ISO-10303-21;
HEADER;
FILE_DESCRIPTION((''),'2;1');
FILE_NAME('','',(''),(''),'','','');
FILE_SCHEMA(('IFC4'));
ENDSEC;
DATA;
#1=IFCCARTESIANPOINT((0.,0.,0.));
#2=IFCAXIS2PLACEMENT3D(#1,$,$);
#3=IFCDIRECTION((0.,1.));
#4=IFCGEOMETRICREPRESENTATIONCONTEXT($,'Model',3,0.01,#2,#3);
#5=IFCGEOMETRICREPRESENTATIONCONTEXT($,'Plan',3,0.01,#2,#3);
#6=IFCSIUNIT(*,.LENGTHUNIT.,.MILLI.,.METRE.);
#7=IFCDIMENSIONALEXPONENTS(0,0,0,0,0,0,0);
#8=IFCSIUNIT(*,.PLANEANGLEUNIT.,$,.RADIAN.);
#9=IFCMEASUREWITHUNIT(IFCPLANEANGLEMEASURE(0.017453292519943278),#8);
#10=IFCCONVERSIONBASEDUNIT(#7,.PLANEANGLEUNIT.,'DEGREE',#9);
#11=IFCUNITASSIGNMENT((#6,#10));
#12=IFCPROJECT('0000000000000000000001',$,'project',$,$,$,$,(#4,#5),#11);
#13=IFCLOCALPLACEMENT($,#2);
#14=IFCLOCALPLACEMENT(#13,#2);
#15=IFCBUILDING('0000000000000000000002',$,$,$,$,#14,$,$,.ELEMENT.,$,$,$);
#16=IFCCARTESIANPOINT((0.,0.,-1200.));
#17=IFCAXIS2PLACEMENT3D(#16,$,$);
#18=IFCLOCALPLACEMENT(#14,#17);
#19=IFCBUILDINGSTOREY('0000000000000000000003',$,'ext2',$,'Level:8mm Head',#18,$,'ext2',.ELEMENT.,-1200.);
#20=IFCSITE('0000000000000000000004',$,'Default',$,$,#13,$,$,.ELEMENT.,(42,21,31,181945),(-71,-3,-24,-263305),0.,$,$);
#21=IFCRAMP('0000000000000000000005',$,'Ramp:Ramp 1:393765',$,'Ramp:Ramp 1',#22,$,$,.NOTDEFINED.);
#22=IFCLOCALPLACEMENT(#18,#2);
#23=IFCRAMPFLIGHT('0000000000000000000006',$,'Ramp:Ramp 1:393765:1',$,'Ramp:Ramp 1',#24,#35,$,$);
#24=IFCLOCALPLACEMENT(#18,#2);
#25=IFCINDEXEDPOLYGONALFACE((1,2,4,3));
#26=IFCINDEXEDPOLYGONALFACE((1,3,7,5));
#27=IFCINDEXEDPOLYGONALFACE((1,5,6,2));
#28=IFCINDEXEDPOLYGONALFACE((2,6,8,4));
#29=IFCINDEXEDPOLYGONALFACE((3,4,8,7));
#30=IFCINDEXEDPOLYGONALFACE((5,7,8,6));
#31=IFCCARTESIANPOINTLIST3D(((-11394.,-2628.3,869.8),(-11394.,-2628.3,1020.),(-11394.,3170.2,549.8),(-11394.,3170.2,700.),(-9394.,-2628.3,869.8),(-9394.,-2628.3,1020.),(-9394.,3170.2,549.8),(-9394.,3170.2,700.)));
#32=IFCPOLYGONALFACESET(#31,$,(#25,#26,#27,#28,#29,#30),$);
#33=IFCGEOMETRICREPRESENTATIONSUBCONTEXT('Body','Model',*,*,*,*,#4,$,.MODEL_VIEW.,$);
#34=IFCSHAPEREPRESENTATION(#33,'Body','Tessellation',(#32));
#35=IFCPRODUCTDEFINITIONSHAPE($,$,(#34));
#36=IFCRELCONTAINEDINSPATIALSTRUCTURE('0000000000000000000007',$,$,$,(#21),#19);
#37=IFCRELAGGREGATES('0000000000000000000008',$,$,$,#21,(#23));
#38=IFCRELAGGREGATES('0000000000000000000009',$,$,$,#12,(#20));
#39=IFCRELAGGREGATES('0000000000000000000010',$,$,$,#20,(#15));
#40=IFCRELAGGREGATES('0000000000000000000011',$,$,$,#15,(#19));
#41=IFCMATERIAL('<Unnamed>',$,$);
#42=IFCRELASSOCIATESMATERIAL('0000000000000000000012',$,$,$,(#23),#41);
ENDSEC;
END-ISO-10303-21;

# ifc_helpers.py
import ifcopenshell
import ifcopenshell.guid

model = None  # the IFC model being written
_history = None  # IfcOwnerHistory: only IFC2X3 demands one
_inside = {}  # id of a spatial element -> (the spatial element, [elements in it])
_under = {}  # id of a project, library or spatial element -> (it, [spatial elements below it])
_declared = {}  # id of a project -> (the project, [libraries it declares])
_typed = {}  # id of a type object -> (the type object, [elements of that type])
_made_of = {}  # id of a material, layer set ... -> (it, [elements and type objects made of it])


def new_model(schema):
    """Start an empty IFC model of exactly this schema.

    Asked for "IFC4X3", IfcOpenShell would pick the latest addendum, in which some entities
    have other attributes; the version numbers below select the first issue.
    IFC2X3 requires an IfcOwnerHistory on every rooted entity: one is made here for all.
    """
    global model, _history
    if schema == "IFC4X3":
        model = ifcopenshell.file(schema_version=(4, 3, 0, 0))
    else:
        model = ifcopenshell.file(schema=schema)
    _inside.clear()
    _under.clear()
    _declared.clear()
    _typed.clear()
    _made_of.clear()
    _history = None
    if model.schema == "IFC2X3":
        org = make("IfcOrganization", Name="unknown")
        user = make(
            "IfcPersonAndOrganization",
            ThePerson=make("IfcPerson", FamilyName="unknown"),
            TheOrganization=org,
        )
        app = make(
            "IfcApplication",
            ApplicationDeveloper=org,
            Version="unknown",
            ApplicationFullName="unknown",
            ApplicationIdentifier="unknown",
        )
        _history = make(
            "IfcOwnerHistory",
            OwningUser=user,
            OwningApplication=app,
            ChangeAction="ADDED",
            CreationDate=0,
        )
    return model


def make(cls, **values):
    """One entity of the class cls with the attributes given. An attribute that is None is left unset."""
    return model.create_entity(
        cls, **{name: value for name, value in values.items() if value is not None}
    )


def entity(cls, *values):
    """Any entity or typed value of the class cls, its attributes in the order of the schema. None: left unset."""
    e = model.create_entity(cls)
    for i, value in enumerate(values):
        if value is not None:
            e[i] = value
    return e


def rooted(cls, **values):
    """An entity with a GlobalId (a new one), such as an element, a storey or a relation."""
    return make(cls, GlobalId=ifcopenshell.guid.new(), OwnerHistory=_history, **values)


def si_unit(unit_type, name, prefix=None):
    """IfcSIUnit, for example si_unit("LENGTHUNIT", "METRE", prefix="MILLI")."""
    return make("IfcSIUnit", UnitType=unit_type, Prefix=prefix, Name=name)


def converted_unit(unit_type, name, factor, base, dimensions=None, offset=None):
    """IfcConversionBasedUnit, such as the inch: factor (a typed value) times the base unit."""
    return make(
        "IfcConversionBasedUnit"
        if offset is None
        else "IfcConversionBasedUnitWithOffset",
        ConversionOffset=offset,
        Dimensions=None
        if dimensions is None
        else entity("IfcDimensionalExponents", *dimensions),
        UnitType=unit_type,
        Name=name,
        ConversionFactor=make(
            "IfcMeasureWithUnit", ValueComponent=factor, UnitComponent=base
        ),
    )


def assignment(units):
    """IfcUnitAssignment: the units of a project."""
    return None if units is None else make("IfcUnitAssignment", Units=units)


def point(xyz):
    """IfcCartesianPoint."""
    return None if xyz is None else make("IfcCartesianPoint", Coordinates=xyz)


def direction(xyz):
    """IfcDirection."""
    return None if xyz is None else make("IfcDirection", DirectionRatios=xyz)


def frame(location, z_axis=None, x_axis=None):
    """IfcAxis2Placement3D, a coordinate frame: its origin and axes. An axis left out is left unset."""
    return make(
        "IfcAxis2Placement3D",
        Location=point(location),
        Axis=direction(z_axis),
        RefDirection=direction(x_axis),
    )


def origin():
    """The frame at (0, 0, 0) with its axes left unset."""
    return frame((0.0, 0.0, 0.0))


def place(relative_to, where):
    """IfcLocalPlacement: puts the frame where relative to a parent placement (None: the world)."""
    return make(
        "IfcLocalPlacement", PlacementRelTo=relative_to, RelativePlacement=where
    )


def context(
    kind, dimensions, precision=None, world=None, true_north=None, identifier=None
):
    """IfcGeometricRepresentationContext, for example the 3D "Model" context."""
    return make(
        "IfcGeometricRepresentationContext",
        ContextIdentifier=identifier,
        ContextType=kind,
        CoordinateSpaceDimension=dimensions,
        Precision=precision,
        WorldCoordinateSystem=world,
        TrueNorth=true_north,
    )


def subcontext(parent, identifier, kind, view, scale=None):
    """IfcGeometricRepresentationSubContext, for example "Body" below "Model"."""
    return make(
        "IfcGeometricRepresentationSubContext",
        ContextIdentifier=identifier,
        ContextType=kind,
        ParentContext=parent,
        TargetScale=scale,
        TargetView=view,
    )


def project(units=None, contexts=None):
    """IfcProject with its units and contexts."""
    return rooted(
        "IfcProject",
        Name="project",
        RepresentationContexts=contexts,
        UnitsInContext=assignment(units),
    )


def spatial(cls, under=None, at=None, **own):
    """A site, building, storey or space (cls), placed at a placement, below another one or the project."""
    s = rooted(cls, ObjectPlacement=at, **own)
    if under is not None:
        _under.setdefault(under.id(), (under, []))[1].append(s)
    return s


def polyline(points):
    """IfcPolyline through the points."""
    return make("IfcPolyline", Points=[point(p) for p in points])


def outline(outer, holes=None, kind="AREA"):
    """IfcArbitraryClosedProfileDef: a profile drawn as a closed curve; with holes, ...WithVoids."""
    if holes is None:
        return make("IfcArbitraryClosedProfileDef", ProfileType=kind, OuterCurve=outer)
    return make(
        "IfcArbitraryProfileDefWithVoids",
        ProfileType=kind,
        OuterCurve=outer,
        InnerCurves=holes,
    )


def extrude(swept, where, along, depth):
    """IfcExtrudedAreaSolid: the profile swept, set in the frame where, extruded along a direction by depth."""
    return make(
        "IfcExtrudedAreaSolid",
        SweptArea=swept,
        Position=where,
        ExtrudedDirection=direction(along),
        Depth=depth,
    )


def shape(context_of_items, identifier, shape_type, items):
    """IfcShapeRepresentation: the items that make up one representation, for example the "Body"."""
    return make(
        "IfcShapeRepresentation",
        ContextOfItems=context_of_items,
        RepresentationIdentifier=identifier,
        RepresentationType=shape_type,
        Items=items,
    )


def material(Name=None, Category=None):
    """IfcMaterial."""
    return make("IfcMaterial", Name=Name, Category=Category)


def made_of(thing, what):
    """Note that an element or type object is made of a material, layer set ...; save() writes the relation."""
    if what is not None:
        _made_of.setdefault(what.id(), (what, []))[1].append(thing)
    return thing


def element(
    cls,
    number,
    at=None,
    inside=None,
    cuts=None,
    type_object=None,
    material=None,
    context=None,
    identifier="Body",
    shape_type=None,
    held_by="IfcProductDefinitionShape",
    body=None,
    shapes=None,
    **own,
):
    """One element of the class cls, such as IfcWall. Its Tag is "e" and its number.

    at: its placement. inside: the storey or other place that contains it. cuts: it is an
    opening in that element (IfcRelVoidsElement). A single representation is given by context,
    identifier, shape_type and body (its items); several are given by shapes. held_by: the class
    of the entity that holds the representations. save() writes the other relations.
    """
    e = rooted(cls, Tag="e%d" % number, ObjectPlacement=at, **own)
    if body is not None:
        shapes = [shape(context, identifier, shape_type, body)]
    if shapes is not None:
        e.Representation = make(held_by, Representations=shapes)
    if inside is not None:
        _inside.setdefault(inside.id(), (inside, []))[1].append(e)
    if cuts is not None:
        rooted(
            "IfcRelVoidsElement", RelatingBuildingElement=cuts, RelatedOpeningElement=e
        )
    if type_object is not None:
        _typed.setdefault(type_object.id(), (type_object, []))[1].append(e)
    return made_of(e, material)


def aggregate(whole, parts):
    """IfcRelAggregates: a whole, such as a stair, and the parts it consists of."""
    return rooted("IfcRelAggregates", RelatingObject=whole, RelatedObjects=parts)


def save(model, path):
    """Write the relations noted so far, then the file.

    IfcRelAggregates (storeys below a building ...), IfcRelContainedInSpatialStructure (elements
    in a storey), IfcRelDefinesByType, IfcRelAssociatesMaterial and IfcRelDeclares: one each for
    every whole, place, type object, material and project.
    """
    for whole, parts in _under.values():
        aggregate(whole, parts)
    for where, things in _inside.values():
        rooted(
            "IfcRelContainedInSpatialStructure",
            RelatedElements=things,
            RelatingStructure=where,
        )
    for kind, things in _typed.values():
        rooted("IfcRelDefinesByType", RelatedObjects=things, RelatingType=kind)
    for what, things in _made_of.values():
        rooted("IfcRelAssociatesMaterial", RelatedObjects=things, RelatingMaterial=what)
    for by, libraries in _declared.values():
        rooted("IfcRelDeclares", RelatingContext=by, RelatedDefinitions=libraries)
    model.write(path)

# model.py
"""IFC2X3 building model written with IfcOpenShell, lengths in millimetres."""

from ifc_helpers import new_model, entity, si_unit, converted_unit, direction, frame, origin, place, context, subcontext, project, spatial, polyline, outline, extrude, material, element, aggregate, save


model = new_model("IFC2X3")

# Units and contexts
model_context = context("Model", 3, precision=0.01, world=origin(), true_north=direction((0.0, 1.0)))
plan_context = context("Plan", 3, precision=0.01, world=origin(), true_north=direction((0.0, 1.0)))
body_context = subcontext(model_context, "Body", "Model", "MODEL_VIEW")
ifc_project = project(units=[si_unit("LENGTHUNIT", "METRE", prefix="MILLI"), converted_unit("PLANEANGLEUNIT", "DEGREE", entity("IfcPlaneAngleMeasure", 0.017453292519943278), si_unit("PLANEANGLEUNIT", "RADIAN"), dimensions=[0, 0, 0, 0, 0, 0, 0])], contexts=[model_context, plan_context])

# Site, building, storey
site_placement = place(None, origin())
site = spatial("IfcSite", under=ifc_project, at=site_placement, Name="Default", CompositionType="ELEMENT", RefLatitude=(42, 21, 31, 181945), RefLongitude=(-71, -3, -24, -263305), RefElevation=0.0)
building_placement = place(site_placement, origin())
building = spatial("IfcBuilding", under=site, at=building_placement, CompositionType="ELEMENT")
storey_placement = place(building_placement, frame((0.0, 0.0, -1200.0)))
storey = spatial("IfcBuildingStorey", under=building, at=storey_placement, Name="ext2", ObjectType="Level:8mm Head", LongName="ext2", CompositionType="ELEMENT", Elevation=-1200.0)

# Ramp, ramp flight
ramp_placement = place(storey_placement, origin())
ramp = element("IfcRamp", 1, at=ramp_placement, inside=storey, Name="Ramp:Ramp 1:393765", ObjectType="Ramp:Ramp 1", ShapeType="NOTDEFINED")
ifc_material = material(Name="<Unnamed>")
ramp_flight_placement = place(ramp_placement, origin())
ramp_flight = element("IfcRampFlight", 2, at=ramp_flight_placement, material=ifc_material, Name="Ramp:Ramp 1:393765:1", ObjectType="Ramp:Ramp 1", context=body_context, shape_type="SweptSolid", body=[
    extrude(outline(polyline([(-235.1, -2899.2), (-84.9, -2899.2), (235.1, 2899.2), (84.9, 2899.2), (-235.1, -2899.2)])), frame((-11394.0, 270.9, 784.9), z_axis=(1.0, 0.0, 0.0), x_axis=(0.0, 0.0, -1.0)), (0.0, 0.0, 1.0), 2000.0),
])
aggregate(ramp, [ramp_flight])

save(model, "model.ifc")
